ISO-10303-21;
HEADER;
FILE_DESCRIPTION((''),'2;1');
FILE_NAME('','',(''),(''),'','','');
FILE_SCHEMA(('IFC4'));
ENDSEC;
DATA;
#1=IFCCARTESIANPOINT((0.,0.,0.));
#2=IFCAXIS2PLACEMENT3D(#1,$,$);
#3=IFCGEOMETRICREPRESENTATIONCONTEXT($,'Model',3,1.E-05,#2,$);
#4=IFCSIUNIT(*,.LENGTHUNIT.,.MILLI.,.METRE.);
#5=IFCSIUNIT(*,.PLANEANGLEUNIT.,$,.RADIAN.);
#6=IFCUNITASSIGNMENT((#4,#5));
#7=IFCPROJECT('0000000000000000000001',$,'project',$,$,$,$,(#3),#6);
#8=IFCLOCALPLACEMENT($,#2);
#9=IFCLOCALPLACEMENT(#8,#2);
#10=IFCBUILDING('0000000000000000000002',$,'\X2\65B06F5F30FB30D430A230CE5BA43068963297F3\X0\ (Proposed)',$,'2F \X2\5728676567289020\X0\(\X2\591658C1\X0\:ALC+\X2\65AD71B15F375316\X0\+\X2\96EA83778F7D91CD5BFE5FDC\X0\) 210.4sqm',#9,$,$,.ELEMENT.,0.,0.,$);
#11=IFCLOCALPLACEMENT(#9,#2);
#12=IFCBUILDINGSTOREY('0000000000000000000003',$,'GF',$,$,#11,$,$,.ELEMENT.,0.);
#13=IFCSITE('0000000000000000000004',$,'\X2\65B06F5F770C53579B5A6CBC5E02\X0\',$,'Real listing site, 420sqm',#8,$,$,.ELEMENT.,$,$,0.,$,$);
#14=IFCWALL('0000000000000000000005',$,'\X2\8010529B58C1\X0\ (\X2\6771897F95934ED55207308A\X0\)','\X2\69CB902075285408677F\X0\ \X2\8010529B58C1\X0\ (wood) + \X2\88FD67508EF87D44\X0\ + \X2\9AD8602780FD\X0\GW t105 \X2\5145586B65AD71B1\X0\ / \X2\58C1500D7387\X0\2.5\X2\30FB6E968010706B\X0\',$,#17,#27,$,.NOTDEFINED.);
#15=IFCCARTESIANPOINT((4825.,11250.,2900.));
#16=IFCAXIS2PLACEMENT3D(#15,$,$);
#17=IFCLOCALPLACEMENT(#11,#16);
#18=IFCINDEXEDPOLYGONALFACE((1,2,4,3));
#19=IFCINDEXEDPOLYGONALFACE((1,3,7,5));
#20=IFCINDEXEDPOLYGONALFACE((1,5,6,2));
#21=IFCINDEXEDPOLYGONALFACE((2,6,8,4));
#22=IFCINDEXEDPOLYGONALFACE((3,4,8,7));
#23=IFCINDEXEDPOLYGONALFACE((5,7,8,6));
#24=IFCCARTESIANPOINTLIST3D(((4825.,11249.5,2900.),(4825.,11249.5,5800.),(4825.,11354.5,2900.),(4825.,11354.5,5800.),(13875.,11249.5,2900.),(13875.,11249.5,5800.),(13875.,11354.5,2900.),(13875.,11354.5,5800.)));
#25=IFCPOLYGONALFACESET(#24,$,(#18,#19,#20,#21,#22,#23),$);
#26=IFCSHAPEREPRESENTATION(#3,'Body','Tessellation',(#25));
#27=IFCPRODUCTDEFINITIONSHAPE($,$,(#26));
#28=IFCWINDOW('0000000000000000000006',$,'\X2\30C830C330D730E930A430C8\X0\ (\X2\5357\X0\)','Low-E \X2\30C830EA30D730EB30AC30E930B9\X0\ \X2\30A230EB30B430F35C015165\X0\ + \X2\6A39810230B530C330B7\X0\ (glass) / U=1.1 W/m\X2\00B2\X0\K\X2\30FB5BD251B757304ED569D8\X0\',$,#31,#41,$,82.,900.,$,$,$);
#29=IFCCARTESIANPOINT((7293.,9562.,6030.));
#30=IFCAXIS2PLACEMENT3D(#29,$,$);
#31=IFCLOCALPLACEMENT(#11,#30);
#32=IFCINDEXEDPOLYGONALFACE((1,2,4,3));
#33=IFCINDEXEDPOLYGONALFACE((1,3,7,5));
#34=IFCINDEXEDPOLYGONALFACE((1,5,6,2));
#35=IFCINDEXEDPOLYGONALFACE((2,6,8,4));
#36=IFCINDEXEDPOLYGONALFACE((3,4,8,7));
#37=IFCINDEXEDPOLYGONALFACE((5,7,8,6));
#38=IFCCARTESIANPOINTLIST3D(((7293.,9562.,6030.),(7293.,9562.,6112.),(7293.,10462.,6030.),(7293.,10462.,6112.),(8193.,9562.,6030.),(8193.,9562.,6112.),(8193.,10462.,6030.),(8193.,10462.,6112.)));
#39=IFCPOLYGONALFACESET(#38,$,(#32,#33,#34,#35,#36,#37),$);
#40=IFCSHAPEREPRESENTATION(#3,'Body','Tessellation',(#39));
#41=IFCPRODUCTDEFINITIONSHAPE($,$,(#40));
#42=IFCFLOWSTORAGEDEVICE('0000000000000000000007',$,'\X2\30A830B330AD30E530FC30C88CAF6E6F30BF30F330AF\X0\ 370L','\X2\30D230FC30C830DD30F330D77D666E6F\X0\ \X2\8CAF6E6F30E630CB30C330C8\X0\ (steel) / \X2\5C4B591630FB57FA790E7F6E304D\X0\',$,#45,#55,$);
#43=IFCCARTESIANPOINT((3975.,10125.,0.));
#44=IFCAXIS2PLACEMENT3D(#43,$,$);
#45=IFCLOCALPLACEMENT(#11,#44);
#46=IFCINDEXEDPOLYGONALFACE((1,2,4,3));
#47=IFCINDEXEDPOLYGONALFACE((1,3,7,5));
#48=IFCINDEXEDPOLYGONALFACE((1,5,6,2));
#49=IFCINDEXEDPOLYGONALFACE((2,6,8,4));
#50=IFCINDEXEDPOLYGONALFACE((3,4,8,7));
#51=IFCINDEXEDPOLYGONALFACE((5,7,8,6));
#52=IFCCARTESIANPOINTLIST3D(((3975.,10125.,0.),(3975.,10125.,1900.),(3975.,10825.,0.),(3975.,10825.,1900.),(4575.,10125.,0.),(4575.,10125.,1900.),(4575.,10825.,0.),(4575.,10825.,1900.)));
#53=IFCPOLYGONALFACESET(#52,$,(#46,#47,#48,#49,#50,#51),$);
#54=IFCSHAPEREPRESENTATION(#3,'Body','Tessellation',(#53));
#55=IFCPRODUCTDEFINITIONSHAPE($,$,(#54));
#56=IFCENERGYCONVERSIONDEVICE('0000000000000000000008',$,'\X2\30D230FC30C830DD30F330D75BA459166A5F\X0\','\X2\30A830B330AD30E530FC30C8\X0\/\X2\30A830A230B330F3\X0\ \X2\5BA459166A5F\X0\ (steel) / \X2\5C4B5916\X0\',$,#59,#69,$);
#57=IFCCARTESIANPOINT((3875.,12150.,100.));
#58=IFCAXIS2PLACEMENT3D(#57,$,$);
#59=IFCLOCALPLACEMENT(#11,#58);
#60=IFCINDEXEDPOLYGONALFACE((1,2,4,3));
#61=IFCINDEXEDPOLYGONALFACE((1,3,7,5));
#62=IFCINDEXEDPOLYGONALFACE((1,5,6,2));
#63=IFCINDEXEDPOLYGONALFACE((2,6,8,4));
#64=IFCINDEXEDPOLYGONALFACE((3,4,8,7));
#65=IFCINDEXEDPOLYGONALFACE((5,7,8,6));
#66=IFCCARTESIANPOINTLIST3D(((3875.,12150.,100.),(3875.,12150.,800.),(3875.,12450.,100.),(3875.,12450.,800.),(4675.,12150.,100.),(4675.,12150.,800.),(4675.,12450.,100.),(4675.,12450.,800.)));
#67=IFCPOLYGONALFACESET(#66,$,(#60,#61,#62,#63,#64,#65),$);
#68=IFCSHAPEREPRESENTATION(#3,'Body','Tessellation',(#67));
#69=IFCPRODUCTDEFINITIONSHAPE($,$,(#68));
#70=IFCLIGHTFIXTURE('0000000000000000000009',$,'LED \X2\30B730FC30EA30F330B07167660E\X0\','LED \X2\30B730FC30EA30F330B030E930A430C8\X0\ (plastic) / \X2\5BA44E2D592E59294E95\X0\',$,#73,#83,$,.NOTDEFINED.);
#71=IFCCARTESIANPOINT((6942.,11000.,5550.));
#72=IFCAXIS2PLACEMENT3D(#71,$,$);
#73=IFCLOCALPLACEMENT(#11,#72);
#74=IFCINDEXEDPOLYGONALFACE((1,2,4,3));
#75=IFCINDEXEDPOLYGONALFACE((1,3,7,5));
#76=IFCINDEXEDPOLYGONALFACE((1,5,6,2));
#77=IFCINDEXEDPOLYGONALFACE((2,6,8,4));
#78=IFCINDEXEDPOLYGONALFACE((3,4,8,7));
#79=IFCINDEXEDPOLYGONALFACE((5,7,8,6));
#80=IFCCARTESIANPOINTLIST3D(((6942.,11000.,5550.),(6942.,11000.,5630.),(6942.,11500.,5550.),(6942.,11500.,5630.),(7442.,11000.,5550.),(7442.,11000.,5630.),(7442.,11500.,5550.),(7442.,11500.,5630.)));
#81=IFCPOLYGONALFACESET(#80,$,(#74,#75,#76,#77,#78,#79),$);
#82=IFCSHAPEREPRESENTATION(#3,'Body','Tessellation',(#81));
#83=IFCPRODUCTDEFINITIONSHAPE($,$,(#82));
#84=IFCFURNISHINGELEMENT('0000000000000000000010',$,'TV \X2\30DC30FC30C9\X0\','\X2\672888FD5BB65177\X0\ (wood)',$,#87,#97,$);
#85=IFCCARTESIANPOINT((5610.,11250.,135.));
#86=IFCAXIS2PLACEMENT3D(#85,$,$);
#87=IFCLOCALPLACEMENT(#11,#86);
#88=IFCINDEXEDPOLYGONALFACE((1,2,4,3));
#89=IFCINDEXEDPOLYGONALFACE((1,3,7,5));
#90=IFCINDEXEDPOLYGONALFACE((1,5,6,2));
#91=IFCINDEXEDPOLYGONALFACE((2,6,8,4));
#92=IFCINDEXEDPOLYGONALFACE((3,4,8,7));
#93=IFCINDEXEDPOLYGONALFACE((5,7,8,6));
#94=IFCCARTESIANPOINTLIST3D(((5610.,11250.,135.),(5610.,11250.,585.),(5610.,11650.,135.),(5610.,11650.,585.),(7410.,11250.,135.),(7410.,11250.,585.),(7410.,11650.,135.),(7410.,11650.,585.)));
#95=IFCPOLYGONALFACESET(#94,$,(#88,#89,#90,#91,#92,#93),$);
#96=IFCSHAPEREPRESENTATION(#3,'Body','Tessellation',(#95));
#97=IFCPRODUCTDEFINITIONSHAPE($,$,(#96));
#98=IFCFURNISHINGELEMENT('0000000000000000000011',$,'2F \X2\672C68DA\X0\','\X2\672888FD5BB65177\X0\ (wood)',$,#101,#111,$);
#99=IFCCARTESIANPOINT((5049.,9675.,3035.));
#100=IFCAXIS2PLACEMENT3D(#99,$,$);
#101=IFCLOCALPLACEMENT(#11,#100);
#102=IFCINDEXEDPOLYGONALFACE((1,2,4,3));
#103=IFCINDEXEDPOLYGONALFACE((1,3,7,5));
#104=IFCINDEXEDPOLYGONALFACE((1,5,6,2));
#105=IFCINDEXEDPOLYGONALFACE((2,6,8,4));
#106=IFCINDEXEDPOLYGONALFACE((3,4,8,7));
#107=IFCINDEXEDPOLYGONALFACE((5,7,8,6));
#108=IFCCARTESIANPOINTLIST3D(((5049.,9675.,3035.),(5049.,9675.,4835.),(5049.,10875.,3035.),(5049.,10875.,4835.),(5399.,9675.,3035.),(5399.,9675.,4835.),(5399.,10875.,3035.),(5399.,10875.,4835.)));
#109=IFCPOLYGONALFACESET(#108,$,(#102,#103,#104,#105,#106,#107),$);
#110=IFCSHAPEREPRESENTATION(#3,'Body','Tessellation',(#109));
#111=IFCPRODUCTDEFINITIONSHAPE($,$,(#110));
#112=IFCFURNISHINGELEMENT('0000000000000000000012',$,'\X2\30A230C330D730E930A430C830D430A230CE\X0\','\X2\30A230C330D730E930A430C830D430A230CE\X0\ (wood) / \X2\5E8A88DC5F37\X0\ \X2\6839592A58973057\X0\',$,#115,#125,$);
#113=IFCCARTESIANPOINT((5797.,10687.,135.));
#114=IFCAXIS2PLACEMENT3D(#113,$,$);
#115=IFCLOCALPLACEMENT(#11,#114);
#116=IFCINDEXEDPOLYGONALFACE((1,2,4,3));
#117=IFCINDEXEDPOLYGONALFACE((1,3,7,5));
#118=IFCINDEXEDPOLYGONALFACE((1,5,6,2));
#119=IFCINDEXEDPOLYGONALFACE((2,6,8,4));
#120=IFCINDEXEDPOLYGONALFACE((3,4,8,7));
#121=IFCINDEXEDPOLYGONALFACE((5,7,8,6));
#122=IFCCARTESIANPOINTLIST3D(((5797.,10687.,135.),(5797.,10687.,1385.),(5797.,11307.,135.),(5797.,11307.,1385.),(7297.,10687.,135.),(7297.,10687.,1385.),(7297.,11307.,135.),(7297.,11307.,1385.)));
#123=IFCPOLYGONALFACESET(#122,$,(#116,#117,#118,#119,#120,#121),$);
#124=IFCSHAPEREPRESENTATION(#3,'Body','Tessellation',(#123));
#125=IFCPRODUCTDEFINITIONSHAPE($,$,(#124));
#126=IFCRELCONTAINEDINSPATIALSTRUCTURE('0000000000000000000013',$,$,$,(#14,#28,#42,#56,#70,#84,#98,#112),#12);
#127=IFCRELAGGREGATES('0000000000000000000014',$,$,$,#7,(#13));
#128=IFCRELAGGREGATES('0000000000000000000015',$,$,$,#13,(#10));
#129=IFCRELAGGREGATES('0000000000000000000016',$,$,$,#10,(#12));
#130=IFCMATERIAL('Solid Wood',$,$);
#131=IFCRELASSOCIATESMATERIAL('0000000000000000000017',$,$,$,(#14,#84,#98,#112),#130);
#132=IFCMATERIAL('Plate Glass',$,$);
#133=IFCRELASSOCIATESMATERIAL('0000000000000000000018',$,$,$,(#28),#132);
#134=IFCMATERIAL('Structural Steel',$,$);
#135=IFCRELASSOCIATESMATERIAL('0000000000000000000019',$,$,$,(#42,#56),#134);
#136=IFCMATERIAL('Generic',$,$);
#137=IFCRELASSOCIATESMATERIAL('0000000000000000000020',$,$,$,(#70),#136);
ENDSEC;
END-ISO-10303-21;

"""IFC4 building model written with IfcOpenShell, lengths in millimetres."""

from ifc_helpers import new_model, si_unit, frame, frame_2d, origin, place, context, project, spatial, rectangle, extrude, material, element, save


model = new_model("IFC4")

# Units and contexts
model_context = context("Model", 3, precision=1e-05, world=origin())
ifc_project = project(units=[si_unit("LENGTHUNIT", "METRE", prefix="MILLI"), si_unit("PLANEANGLEUNIT", "RADIAN")], contexts=[model_context])

# Site, building, storey
site_placement = place(None, origin())
site = spatial("IfcSite", under=ifc_project, at=site_placement, Name="新潟県南魚沼市", ObjectType="Real listing site, 420sqm", CompositionType="ELEMENT", RefElevation=0.0)
building_placement = place(site_placement, origin())
building = spatial("IfcBuilding", under=site, at=building_placement, Name="新潟・ピアノ室と防音 (Proposed)", ObjectType="2F 在来木造(外壁:ALC+断熱強化+雪荷载重対応) 210.4sqm", CompositionType="ELEMENT", ElevationOfRefHeight=0.0, ElevationOfTerrain=0.0)
storey_placement = place(building_placement, origin())
storey = spatial("IfcBuildingStorey", under=building, at=storey_placement, Name="GF", CompositionType="ELEMENT", Elevation=0.0)

# Shared definitions
ifc_material_1 = material(Name="Solid Wood")

# Wall
wall_1_placement = place(storey_placement, frame((4825.0, 11250.0, 2900.0)))
element("IfcWall", 1, at=wall_1_placement, inside=storey, material=ifc_material_1, Name="耐力壁 (東西間仕切り)", Description="構造用合板 耐力壁 (wood) + 製材軸組 + 高性能GW t105 充填断熱 / 壁倍率2.5・準耐火", PredefinedType="NOTDEFINED", context=model_context, shape_type="SweptSolid", body=[
    extrude(rectangle(XDim=9050.0, YDim=105.0, at=frame_2d((4525.0, 52.0))), frame((4825.0, 11250.0, 2900.0)), (0.0, 0.0, 1.0), 2900.0),
])

# Window
ifc_material_2 = material(Name="Plate Glass")
window_placement = place(storey_placement, frame((7293.0, 9562.0, 6030.0)))
element("IfcWindow", 2, at=window_placement, inside=storey, material=ifc_material_2, Name="トップライト (南)", Description="Low-E トリプルガラス アルゴン封入 + 樹脂サッシ (glass) / U=1.1 W/m²K・寒冷地仕様", OverallHeight=82.0, OverallWidth=900.0, context=model_context, shape_type="SweptSolid", body=[
    extrude(rectangle(XDim=900.0, YDim=900.0, at=frame_2d((450.0, 450.0))), frame((7293.0, 9562.0, 6030.0)), (0.0, 0.0, 1.0), 82.0),
])

# Flow storage device
ifc_material_3 = material(Name="Structural Steel")
flow_storage_device_placement = place(storey_placement, frame((3975.0, 10125.0, 0.0)))
element("IfcFlowStorageDevice", 3, at=flow_storage_device_placement, inside=storey, material=ifc_material_3, Name="エコキュート貯湯タンク 370L", Description="ヒートポンプ給湯 貯湯ユニット (steel) / 屋外・基礎置き", context=model_context, shape_type="SweptSolid", body=[
    extrude(rectangle(XDim=600.0, YDim=700.0, at=frame_2d((300.0, 350.0))), frame((3975.0, 10125.0, 0.0)), (0.0, 0.0, 1.0), 1900.0),
])

# Energy conversion device
energy_conversion_device_placement = place(storey_placement, frame((3875.0, 12150.0, 100.0)))
element("IfcEnergyConversionDevice", 4, at=energy_conversion_device_placement, inside=storey, material=ifc_material_3, Name="ヒートポンプ室外機", Description="エコキュート/エアコン 室外機 (steel) / 屋外", context=model_context, shape_type="SweptSolid", body=[
    extrude(rectangle(XDim=800.0, YDim=300.0, at=frame_2d((400.0, 150.0))), frame((3875.0, 12150.0, 100.0)), (0.0, 0.0, 1.0), 700.0),
])

# Light fixture
ifc_material_4 = material(Name="Generic")
light_fixture_placement = place(storey_placement, frame((6942.0, 11000.0, 5550.0)))
element("IfcLightFixture", 5, at=light_fixture_placement, inside=storey, material=ifc_material_4, Name="LED シーリング照明", Description="LED シーリングライト (plastic) / 室中央天井", PredefinedType="NOTDEFINED", context=model_context, shape_type="SweptSolid", body=[
    extrude(rectangle(XDim=500.0, YDim=500.0, at=frame_2d((250.0, 250.0))), frame((6942.0, 11000.0, 5550.0)), (0.0, 0.0, 1.0), 80.0),
])

# Furnishing elements
furnishing_1_placement = place(storey_placement, frame((5610.0, 11250.0, 135.0)))
element("IfcFurnishingElement", 6, at=furnishing_1_placement, inside=storey, material=ifc_material_1, Name="TV ボード", Description="木製家具 (wood)", context=model_context, shape_type="SweptSolid", body=[
    extrude(rectangle(XDim=1800.0, YDim=400.0, at=frame_2d((900.0, 200.0))), frame((5610.0, 11250.0, 135.0)), (0.0, 0.0, 1.0), 450.0),
])
furnishing_2_placement = place(storey_placement, frame((5049.0, 9675.0, 3035.0)))
element("IfcFurnishingElement", 7, at=furnishing_2_placement, inside=storey, material=ifc_material_1, Name="2F 本棚", Description="木製家具 (wood)", context=model_context, shape_type="SweptSolid", body=[
    extrude(rectangle(XDim=350.0, YDim=1200.0, at=frame_2d((175.0, 600.0))), frame((5049.0, 9675.0, 3035.0)), (0.0, 0.0, 1.0), 1800.0),
])
furnishing_3_placement = place(storey_placement, frame((5797.0, 10687.0, 135.0)))
element("IfcFurnishingElement", 8, at=furnishing_3_placement, inside=storey, material=ifc_material_1, Name="アップライトピアノ", Description="アップライトピアノ (wood) / 床補強 根太増し", context=model_context, shape_type="SweptSolid", body=[
    extrude(rectangle(XDim=1500.0, YDim=620.0, at=frame_2d((750.0, 310.0))), frame((5797.0, 10687.0, 135.0)), (0.0, 0.0, 1.0), 1250.0),
])

save(model, "model.ifc")
